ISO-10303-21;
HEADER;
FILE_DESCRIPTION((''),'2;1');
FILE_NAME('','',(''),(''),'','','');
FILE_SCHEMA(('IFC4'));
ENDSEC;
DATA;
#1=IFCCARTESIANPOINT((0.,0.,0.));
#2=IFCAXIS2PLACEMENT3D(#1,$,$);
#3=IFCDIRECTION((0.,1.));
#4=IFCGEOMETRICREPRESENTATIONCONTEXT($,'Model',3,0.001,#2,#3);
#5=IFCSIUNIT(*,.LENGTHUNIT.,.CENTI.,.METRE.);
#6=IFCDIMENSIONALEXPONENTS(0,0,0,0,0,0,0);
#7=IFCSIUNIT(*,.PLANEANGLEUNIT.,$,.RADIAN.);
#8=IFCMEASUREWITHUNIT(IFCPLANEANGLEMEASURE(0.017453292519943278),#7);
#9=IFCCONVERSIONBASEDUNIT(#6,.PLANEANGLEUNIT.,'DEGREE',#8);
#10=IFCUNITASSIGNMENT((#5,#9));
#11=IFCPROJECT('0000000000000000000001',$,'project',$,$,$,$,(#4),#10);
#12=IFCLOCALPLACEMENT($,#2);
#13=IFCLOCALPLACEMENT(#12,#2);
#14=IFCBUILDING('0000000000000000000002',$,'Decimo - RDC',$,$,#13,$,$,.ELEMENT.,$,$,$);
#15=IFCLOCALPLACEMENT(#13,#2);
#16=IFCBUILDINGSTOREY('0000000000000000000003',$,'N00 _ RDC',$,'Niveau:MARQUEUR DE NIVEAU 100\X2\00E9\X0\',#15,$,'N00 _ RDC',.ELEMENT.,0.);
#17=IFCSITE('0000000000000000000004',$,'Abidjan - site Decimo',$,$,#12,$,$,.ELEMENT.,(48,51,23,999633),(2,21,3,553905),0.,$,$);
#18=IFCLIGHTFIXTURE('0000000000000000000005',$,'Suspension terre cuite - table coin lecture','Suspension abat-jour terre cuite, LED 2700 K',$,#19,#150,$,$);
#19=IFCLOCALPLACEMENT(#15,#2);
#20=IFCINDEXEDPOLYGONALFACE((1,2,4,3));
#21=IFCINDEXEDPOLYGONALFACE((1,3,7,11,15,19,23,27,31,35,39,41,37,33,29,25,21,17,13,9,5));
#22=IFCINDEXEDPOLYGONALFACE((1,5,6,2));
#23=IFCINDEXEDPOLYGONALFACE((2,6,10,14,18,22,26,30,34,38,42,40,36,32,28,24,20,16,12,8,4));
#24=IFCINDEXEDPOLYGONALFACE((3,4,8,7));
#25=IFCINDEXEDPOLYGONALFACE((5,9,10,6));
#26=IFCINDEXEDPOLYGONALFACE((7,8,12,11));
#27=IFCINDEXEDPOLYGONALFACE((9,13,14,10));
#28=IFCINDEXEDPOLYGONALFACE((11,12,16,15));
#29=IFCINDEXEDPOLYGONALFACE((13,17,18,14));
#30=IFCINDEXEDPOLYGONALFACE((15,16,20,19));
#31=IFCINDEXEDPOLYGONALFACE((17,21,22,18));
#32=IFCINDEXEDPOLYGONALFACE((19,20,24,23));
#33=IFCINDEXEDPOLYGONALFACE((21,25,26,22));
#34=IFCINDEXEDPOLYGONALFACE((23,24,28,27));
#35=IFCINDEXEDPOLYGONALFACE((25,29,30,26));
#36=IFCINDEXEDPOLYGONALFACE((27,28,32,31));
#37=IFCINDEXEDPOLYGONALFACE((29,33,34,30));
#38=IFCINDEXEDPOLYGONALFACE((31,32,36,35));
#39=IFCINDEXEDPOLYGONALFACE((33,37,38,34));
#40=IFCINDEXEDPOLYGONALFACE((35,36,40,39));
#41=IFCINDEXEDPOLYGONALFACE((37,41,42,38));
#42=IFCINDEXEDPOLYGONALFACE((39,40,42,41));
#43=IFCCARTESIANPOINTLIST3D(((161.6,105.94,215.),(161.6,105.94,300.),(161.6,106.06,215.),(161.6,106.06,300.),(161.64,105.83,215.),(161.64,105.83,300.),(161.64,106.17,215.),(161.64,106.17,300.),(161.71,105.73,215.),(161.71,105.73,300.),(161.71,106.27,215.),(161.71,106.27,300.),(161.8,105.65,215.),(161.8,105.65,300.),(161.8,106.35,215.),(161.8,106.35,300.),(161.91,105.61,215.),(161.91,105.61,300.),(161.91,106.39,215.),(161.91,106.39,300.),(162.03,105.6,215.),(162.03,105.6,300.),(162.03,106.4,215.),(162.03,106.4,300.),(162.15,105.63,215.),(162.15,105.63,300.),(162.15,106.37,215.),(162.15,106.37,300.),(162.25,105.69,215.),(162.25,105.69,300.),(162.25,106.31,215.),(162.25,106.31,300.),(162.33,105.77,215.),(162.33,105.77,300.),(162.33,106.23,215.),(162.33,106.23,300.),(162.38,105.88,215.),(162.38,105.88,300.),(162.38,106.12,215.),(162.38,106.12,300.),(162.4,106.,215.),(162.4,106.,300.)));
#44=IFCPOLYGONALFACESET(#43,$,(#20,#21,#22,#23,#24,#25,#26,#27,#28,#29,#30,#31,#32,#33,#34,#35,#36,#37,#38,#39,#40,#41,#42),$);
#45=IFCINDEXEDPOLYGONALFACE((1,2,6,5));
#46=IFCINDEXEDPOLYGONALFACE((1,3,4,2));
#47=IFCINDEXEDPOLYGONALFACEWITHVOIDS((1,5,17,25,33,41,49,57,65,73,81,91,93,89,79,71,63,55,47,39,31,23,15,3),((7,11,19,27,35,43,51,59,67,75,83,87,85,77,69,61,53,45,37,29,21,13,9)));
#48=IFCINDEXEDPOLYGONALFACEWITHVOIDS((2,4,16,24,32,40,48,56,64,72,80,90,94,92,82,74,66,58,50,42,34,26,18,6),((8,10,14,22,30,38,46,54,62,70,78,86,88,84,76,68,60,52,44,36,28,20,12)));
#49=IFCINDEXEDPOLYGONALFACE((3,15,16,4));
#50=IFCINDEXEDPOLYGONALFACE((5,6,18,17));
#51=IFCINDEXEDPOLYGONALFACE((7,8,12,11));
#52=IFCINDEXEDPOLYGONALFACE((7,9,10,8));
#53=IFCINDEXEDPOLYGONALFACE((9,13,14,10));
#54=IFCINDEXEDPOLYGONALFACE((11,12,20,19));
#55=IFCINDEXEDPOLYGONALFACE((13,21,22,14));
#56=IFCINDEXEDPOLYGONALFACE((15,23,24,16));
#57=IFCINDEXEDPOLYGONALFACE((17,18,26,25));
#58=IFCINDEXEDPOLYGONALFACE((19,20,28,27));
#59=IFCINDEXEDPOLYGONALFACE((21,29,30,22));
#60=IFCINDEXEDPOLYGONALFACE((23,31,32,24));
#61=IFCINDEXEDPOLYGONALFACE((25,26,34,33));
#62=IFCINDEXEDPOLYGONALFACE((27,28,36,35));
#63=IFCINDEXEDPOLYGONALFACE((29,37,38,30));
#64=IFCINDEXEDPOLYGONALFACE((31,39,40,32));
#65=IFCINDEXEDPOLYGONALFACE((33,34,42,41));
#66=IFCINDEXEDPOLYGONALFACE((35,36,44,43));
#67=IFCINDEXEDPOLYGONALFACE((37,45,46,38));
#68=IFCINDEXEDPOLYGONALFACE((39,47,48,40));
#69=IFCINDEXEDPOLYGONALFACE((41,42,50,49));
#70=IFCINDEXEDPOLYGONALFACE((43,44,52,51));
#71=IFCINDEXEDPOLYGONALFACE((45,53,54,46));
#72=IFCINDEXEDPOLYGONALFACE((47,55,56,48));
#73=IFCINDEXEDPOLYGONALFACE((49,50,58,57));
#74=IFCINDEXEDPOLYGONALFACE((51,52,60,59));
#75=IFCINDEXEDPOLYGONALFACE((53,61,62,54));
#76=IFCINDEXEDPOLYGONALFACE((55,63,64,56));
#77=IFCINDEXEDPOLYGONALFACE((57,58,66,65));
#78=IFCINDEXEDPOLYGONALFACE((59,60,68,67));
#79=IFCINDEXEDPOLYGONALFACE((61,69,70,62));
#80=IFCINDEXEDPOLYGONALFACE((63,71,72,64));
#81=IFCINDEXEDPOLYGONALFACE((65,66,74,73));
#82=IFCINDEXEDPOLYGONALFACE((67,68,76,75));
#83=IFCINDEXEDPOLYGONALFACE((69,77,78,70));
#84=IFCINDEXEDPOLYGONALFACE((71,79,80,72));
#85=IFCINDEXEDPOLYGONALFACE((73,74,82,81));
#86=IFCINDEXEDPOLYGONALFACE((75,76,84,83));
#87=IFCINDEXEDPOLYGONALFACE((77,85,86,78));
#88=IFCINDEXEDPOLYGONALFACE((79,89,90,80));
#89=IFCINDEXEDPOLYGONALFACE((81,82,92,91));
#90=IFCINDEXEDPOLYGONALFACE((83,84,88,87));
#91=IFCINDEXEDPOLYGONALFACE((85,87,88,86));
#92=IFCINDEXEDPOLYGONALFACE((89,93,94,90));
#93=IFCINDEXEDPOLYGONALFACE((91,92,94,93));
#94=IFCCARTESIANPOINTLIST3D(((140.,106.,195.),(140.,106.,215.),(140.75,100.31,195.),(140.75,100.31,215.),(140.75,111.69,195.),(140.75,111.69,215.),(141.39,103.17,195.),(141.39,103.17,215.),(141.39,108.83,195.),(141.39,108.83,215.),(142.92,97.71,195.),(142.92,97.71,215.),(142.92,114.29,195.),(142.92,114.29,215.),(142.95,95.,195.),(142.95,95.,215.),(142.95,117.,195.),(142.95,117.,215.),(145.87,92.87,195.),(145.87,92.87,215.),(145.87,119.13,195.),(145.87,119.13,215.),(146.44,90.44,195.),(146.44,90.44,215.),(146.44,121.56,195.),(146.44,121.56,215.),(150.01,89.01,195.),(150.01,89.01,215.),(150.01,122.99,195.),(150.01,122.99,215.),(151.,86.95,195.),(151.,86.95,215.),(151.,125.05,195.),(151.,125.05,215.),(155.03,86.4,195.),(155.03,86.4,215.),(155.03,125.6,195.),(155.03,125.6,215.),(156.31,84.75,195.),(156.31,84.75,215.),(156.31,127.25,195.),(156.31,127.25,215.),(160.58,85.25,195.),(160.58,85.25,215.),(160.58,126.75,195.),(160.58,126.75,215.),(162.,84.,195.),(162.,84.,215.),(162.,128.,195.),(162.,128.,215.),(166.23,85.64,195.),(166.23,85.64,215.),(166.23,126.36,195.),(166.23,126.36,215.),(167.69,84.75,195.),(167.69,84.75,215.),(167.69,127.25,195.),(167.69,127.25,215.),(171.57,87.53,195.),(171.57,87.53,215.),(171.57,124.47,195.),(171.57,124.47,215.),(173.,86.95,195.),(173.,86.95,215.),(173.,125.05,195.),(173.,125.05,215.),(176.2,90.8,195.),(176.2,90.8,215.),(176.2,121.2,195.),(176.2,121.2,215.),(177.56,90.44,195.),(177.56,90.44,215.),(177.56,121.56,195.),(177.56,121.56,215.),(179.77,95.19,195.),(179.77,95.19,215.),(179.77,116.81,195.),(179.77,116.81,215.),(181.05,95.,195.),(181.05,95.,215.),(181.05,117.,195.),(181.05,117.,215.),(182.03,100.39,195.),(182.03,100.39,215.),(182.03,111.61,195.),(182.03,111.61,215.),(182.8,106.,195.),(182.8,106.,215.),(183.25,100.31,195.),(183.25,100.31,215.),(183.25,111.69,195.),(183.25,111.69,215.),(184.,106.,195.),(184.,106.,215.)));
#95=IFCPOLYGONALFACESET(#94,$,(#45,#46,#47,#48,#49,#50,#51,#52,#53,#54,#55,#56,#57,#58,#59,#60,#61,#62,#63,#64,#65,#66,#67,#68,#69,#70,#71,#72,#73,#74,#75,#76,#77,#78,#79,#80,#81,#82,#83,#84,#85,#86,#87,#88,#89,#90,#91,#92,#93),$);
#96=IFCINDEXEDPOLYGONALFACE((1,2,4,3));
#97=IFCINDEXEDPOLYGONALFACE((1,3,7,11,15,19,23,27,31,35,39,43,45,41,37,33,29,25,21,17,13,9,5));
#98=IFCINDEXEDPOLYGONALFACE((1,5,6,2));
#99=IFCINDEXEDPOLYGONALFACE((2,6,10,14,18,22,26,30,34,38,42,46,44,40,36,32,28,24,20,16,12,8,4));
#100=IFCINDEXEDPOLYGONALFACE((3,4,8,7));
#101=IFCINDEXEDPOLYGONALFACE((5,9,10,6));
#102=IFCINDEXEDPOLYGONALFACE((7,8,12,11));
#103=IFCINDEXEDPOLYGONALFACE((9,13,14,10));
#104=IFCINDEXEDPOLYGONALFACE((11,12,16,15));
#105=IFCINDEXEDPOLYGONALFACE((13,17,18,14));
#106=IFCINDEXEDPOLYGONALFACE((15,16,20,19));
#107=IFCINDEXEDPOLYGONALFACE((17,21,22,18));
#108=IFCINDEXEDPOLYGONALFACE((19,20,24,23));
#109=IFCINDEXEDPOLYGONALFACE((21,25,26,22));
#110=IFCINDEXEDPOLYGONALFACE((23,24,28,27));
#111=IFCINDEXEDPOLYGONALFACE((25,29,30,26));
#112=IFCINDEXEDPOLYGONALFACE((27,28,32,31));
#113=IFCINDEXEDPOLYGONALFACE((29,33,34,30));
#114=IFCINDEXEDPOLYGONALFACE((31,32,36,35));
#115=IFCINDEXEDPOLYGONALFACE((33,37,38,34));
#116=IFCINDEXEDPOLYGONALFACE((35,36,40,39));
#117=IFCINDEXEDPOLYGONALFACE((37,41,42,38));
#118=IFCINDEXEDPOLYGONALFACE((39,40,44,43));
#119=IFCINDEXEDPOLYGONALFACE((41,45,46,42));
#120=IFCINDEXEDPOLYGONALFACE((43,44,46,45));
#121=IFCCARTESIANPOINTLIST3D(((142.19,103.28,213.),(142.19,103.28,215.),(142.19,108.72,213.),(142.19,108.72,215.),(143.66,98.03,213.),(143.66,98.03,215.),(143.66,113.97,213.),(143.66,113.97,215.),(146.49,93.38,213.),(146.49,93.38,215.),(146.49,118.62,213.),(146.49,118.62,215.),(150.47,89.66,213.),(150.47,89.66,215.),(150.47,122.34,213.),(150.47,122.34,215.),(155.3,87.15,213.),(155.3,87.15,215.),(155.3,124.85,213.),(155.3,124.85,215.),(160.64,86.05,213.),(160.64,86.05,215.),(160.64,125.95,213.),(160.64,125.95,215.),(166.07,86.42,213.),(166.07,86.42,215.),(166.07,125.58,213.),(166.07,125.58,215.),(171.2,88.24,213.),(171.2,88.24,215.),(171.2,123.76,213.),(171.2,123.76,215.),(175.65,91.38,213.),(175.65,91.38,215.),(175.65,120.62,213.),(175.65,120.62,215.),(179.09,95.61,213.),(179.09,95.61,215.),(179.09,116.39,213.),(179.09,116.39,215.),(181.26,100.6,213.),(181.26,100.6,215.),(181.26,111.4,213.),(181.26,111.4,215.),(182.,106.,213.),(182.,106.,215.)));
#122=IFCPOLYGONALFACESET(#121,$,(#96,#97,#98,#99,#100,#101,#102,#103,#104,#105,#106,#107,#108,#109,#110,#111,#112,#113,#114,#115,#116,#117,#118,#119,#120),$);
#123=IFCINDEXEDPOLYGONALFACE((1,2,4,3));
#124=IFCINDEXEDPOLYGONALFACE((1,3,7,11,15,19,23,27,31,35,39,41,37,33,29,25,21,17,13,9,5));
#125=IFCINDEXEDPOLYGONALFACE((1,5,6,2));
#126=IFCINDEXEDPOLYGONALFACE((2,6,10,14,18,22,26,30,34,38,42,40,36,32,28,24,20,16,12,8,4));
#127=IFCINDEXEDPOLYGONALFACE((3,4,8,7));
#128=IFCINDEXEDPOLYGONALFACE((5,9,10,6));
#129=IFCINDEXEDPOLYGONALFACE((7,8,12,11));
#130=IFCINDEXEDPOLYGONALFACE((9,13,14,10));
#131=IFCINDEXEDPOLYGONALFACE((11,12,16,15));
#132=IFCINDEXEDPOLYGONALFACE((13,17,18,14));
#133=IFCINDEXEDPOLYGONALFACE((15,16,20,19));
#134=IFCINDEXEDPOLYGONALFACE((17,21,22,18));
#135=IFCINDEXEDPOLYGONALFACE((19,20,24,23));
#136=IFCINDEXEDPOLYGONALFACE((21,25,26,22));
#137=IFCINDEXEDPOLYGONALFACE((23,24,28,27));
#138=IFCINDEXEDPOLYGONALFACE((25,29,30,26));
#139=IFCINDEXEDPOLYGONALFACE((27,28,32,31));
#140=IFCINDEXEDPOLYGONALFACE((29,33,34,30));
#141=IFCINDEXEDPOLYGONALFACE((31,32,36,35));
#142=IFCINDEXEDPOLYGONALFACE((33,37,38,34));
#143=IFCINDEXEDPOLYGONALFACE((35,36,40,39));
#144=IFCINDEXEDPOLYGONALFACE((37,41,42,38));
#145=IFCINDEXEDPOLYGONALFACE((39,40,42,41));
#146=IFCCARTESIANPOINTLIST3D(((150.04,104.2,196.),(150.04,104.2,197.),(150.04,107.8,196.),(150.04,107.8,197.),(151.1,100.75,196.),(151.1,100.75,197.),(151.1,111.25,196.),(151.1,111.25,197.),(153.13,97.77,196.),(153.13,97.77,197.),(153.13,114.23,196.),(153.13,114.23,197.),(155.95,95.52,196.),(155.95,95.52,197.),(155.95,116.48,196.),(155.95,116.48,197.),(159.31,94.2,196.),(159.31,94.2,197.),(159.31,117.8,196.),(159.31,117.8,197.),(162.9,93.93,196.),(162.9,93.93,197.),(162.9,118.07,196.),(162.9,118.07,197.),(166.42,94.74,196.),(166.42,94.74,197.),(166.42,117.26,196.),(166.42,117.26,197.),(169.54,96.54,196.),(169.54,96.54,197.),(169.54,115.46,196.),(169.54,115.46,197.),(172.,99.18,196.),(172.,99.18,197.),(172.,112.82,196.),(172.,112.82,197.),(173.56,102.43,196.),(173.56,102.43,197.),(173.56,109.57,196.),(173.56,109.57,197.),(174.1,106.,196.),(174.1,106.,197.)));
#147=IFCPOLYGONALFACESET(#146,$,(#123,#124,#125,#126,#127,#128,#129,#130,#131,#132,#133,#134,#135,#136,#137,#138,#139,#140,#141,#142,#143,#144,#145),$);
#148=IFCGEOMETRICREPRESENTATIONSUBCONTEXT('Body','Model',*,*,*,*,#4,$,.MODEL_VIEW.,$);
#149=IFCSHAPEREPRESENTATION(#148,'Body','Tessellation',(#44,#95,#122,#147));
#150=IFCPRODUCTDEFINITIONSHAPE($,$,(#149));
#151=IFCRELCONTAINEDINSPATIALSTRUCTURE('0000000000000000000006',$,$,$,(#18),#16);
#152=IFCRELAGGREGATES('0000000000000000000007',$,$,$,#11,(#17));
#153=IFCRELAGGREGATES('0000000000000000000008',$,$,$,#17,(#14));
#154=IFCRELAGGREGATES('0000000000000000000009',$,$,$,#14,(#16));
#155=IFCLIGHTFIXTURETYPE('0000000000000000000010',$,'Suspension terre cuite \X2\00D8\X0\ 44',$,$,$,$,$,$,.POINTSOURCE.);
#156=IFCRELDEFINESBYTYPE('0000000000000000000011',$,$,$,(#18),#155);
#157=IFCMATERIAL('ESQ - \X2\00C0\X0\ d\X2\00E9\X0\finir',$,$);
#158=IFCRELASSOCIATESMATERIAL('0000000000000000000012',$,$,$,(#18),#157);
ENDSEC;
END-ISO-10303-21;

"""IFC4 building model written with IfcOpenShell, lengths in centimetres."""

from ifc_helpers import new_model, entity, si_unit, converted_unit, direction, frame, frame_2d, origin, origin_with_axes, place, context, subcontext, project, spatial, circle, hollow_circle, extrude, material, type_object, element, save


model = new_model("IFC4")

# Units and contexts
model_context = context("Model", 3, precision=0.001, world=origin(), true_north=direction((0.0, 1.0)))
body_context = subcontext(model_context, "Body", "Model", "MODEL_VIEW")
ifc_project = project(units=[si_unit("LENGTHUNIT", "METRE", prefix="CENTI"), converted_unit("PLANEANGLEUNIT", "DEGREE", entity("IfcPlaneAngleMeasure", 0.017453292519943278), si_unit("PLANEANGLEUNIT", "RADIAN"), dimensions=[0, 0, 0, 0, 0, 0, 0])], contexts=[model_context])

# Site, building, storey
site_placement = place(None, origin())
site = spatial("IfcSite", under=ifc_project, at=site_placement, Name="Abidjan - site Decimo", CompositionType="ELEMENT", RefLatitude=(48, 51, 23, 999633), RefLongitude=(2, 21, 3, 553905), RefElevation=0.0)
building_placement = place(site_placement, origin())
building = spatial("IfcBuilding", under=site, at=building_placement, Name="Decimo - RDC", CompositionType="ELEMENT")
storey_placement = place(building_placement, origin())
storey = spatial("IfcBuildingStorey", under=building, at=storey_placement, Name="N00 _ RDC", ObjectType="Niveau:MARQUEUR DE NIVEAU 100é", LongName="N00 _ RDC", CompositionType="ELEMENT", Elevation=0.0)

# Light fixture
ifc_material_1 = material(Name="ESQ - À définir")
light_fixture_type_1 = type_object("IfcLightFixtureType", Name="Suspension terre cuite Ø 44", PredefinedType="POINTSOURCE")
light_fixture_1_placement = place(storey_placement, origin_with_axes())
element("IfcLightFixture", 1, at=light_fixture_1_placement, inside=storey, type_object=light_fixture_type_1, material=ifc_material_1, Name="Suspension terre cuite - table coin lecture", Description="Suspension abat-jour terre cuite, LED 2700 K", context=body_context, shape_type="SweptSolid", body=[
    extrude(circle(Radius=0.4, at=frame_2d((162.0, 106.0))), frame((0.0, 0.0, 215.0)), (0.0, 0.0, 1.0), 85.0),
    extrude(hollow_circle(Radius=22.0, WallThickness=1.2, at=frame_2d((162.0, 106.0))), frame((0.0, 0.0, 195.0)), (0.0, 0.0, 1.0), 20.0),
    extrude(circle(Radius=20.0, at=frame_2d((162.0, 106.0))), frame((0.0, 0.0, 213.0)), (0.0, 0.0, 1.0), 2.0),
    extrude(circle(Radius=12.1, at=frame_2d((162.0, 106.0))), frame((0.0, 0.0, 196.0)), (0.0, 0.0, 1.0), 1.0),
])

save(model, "model.ifc")
